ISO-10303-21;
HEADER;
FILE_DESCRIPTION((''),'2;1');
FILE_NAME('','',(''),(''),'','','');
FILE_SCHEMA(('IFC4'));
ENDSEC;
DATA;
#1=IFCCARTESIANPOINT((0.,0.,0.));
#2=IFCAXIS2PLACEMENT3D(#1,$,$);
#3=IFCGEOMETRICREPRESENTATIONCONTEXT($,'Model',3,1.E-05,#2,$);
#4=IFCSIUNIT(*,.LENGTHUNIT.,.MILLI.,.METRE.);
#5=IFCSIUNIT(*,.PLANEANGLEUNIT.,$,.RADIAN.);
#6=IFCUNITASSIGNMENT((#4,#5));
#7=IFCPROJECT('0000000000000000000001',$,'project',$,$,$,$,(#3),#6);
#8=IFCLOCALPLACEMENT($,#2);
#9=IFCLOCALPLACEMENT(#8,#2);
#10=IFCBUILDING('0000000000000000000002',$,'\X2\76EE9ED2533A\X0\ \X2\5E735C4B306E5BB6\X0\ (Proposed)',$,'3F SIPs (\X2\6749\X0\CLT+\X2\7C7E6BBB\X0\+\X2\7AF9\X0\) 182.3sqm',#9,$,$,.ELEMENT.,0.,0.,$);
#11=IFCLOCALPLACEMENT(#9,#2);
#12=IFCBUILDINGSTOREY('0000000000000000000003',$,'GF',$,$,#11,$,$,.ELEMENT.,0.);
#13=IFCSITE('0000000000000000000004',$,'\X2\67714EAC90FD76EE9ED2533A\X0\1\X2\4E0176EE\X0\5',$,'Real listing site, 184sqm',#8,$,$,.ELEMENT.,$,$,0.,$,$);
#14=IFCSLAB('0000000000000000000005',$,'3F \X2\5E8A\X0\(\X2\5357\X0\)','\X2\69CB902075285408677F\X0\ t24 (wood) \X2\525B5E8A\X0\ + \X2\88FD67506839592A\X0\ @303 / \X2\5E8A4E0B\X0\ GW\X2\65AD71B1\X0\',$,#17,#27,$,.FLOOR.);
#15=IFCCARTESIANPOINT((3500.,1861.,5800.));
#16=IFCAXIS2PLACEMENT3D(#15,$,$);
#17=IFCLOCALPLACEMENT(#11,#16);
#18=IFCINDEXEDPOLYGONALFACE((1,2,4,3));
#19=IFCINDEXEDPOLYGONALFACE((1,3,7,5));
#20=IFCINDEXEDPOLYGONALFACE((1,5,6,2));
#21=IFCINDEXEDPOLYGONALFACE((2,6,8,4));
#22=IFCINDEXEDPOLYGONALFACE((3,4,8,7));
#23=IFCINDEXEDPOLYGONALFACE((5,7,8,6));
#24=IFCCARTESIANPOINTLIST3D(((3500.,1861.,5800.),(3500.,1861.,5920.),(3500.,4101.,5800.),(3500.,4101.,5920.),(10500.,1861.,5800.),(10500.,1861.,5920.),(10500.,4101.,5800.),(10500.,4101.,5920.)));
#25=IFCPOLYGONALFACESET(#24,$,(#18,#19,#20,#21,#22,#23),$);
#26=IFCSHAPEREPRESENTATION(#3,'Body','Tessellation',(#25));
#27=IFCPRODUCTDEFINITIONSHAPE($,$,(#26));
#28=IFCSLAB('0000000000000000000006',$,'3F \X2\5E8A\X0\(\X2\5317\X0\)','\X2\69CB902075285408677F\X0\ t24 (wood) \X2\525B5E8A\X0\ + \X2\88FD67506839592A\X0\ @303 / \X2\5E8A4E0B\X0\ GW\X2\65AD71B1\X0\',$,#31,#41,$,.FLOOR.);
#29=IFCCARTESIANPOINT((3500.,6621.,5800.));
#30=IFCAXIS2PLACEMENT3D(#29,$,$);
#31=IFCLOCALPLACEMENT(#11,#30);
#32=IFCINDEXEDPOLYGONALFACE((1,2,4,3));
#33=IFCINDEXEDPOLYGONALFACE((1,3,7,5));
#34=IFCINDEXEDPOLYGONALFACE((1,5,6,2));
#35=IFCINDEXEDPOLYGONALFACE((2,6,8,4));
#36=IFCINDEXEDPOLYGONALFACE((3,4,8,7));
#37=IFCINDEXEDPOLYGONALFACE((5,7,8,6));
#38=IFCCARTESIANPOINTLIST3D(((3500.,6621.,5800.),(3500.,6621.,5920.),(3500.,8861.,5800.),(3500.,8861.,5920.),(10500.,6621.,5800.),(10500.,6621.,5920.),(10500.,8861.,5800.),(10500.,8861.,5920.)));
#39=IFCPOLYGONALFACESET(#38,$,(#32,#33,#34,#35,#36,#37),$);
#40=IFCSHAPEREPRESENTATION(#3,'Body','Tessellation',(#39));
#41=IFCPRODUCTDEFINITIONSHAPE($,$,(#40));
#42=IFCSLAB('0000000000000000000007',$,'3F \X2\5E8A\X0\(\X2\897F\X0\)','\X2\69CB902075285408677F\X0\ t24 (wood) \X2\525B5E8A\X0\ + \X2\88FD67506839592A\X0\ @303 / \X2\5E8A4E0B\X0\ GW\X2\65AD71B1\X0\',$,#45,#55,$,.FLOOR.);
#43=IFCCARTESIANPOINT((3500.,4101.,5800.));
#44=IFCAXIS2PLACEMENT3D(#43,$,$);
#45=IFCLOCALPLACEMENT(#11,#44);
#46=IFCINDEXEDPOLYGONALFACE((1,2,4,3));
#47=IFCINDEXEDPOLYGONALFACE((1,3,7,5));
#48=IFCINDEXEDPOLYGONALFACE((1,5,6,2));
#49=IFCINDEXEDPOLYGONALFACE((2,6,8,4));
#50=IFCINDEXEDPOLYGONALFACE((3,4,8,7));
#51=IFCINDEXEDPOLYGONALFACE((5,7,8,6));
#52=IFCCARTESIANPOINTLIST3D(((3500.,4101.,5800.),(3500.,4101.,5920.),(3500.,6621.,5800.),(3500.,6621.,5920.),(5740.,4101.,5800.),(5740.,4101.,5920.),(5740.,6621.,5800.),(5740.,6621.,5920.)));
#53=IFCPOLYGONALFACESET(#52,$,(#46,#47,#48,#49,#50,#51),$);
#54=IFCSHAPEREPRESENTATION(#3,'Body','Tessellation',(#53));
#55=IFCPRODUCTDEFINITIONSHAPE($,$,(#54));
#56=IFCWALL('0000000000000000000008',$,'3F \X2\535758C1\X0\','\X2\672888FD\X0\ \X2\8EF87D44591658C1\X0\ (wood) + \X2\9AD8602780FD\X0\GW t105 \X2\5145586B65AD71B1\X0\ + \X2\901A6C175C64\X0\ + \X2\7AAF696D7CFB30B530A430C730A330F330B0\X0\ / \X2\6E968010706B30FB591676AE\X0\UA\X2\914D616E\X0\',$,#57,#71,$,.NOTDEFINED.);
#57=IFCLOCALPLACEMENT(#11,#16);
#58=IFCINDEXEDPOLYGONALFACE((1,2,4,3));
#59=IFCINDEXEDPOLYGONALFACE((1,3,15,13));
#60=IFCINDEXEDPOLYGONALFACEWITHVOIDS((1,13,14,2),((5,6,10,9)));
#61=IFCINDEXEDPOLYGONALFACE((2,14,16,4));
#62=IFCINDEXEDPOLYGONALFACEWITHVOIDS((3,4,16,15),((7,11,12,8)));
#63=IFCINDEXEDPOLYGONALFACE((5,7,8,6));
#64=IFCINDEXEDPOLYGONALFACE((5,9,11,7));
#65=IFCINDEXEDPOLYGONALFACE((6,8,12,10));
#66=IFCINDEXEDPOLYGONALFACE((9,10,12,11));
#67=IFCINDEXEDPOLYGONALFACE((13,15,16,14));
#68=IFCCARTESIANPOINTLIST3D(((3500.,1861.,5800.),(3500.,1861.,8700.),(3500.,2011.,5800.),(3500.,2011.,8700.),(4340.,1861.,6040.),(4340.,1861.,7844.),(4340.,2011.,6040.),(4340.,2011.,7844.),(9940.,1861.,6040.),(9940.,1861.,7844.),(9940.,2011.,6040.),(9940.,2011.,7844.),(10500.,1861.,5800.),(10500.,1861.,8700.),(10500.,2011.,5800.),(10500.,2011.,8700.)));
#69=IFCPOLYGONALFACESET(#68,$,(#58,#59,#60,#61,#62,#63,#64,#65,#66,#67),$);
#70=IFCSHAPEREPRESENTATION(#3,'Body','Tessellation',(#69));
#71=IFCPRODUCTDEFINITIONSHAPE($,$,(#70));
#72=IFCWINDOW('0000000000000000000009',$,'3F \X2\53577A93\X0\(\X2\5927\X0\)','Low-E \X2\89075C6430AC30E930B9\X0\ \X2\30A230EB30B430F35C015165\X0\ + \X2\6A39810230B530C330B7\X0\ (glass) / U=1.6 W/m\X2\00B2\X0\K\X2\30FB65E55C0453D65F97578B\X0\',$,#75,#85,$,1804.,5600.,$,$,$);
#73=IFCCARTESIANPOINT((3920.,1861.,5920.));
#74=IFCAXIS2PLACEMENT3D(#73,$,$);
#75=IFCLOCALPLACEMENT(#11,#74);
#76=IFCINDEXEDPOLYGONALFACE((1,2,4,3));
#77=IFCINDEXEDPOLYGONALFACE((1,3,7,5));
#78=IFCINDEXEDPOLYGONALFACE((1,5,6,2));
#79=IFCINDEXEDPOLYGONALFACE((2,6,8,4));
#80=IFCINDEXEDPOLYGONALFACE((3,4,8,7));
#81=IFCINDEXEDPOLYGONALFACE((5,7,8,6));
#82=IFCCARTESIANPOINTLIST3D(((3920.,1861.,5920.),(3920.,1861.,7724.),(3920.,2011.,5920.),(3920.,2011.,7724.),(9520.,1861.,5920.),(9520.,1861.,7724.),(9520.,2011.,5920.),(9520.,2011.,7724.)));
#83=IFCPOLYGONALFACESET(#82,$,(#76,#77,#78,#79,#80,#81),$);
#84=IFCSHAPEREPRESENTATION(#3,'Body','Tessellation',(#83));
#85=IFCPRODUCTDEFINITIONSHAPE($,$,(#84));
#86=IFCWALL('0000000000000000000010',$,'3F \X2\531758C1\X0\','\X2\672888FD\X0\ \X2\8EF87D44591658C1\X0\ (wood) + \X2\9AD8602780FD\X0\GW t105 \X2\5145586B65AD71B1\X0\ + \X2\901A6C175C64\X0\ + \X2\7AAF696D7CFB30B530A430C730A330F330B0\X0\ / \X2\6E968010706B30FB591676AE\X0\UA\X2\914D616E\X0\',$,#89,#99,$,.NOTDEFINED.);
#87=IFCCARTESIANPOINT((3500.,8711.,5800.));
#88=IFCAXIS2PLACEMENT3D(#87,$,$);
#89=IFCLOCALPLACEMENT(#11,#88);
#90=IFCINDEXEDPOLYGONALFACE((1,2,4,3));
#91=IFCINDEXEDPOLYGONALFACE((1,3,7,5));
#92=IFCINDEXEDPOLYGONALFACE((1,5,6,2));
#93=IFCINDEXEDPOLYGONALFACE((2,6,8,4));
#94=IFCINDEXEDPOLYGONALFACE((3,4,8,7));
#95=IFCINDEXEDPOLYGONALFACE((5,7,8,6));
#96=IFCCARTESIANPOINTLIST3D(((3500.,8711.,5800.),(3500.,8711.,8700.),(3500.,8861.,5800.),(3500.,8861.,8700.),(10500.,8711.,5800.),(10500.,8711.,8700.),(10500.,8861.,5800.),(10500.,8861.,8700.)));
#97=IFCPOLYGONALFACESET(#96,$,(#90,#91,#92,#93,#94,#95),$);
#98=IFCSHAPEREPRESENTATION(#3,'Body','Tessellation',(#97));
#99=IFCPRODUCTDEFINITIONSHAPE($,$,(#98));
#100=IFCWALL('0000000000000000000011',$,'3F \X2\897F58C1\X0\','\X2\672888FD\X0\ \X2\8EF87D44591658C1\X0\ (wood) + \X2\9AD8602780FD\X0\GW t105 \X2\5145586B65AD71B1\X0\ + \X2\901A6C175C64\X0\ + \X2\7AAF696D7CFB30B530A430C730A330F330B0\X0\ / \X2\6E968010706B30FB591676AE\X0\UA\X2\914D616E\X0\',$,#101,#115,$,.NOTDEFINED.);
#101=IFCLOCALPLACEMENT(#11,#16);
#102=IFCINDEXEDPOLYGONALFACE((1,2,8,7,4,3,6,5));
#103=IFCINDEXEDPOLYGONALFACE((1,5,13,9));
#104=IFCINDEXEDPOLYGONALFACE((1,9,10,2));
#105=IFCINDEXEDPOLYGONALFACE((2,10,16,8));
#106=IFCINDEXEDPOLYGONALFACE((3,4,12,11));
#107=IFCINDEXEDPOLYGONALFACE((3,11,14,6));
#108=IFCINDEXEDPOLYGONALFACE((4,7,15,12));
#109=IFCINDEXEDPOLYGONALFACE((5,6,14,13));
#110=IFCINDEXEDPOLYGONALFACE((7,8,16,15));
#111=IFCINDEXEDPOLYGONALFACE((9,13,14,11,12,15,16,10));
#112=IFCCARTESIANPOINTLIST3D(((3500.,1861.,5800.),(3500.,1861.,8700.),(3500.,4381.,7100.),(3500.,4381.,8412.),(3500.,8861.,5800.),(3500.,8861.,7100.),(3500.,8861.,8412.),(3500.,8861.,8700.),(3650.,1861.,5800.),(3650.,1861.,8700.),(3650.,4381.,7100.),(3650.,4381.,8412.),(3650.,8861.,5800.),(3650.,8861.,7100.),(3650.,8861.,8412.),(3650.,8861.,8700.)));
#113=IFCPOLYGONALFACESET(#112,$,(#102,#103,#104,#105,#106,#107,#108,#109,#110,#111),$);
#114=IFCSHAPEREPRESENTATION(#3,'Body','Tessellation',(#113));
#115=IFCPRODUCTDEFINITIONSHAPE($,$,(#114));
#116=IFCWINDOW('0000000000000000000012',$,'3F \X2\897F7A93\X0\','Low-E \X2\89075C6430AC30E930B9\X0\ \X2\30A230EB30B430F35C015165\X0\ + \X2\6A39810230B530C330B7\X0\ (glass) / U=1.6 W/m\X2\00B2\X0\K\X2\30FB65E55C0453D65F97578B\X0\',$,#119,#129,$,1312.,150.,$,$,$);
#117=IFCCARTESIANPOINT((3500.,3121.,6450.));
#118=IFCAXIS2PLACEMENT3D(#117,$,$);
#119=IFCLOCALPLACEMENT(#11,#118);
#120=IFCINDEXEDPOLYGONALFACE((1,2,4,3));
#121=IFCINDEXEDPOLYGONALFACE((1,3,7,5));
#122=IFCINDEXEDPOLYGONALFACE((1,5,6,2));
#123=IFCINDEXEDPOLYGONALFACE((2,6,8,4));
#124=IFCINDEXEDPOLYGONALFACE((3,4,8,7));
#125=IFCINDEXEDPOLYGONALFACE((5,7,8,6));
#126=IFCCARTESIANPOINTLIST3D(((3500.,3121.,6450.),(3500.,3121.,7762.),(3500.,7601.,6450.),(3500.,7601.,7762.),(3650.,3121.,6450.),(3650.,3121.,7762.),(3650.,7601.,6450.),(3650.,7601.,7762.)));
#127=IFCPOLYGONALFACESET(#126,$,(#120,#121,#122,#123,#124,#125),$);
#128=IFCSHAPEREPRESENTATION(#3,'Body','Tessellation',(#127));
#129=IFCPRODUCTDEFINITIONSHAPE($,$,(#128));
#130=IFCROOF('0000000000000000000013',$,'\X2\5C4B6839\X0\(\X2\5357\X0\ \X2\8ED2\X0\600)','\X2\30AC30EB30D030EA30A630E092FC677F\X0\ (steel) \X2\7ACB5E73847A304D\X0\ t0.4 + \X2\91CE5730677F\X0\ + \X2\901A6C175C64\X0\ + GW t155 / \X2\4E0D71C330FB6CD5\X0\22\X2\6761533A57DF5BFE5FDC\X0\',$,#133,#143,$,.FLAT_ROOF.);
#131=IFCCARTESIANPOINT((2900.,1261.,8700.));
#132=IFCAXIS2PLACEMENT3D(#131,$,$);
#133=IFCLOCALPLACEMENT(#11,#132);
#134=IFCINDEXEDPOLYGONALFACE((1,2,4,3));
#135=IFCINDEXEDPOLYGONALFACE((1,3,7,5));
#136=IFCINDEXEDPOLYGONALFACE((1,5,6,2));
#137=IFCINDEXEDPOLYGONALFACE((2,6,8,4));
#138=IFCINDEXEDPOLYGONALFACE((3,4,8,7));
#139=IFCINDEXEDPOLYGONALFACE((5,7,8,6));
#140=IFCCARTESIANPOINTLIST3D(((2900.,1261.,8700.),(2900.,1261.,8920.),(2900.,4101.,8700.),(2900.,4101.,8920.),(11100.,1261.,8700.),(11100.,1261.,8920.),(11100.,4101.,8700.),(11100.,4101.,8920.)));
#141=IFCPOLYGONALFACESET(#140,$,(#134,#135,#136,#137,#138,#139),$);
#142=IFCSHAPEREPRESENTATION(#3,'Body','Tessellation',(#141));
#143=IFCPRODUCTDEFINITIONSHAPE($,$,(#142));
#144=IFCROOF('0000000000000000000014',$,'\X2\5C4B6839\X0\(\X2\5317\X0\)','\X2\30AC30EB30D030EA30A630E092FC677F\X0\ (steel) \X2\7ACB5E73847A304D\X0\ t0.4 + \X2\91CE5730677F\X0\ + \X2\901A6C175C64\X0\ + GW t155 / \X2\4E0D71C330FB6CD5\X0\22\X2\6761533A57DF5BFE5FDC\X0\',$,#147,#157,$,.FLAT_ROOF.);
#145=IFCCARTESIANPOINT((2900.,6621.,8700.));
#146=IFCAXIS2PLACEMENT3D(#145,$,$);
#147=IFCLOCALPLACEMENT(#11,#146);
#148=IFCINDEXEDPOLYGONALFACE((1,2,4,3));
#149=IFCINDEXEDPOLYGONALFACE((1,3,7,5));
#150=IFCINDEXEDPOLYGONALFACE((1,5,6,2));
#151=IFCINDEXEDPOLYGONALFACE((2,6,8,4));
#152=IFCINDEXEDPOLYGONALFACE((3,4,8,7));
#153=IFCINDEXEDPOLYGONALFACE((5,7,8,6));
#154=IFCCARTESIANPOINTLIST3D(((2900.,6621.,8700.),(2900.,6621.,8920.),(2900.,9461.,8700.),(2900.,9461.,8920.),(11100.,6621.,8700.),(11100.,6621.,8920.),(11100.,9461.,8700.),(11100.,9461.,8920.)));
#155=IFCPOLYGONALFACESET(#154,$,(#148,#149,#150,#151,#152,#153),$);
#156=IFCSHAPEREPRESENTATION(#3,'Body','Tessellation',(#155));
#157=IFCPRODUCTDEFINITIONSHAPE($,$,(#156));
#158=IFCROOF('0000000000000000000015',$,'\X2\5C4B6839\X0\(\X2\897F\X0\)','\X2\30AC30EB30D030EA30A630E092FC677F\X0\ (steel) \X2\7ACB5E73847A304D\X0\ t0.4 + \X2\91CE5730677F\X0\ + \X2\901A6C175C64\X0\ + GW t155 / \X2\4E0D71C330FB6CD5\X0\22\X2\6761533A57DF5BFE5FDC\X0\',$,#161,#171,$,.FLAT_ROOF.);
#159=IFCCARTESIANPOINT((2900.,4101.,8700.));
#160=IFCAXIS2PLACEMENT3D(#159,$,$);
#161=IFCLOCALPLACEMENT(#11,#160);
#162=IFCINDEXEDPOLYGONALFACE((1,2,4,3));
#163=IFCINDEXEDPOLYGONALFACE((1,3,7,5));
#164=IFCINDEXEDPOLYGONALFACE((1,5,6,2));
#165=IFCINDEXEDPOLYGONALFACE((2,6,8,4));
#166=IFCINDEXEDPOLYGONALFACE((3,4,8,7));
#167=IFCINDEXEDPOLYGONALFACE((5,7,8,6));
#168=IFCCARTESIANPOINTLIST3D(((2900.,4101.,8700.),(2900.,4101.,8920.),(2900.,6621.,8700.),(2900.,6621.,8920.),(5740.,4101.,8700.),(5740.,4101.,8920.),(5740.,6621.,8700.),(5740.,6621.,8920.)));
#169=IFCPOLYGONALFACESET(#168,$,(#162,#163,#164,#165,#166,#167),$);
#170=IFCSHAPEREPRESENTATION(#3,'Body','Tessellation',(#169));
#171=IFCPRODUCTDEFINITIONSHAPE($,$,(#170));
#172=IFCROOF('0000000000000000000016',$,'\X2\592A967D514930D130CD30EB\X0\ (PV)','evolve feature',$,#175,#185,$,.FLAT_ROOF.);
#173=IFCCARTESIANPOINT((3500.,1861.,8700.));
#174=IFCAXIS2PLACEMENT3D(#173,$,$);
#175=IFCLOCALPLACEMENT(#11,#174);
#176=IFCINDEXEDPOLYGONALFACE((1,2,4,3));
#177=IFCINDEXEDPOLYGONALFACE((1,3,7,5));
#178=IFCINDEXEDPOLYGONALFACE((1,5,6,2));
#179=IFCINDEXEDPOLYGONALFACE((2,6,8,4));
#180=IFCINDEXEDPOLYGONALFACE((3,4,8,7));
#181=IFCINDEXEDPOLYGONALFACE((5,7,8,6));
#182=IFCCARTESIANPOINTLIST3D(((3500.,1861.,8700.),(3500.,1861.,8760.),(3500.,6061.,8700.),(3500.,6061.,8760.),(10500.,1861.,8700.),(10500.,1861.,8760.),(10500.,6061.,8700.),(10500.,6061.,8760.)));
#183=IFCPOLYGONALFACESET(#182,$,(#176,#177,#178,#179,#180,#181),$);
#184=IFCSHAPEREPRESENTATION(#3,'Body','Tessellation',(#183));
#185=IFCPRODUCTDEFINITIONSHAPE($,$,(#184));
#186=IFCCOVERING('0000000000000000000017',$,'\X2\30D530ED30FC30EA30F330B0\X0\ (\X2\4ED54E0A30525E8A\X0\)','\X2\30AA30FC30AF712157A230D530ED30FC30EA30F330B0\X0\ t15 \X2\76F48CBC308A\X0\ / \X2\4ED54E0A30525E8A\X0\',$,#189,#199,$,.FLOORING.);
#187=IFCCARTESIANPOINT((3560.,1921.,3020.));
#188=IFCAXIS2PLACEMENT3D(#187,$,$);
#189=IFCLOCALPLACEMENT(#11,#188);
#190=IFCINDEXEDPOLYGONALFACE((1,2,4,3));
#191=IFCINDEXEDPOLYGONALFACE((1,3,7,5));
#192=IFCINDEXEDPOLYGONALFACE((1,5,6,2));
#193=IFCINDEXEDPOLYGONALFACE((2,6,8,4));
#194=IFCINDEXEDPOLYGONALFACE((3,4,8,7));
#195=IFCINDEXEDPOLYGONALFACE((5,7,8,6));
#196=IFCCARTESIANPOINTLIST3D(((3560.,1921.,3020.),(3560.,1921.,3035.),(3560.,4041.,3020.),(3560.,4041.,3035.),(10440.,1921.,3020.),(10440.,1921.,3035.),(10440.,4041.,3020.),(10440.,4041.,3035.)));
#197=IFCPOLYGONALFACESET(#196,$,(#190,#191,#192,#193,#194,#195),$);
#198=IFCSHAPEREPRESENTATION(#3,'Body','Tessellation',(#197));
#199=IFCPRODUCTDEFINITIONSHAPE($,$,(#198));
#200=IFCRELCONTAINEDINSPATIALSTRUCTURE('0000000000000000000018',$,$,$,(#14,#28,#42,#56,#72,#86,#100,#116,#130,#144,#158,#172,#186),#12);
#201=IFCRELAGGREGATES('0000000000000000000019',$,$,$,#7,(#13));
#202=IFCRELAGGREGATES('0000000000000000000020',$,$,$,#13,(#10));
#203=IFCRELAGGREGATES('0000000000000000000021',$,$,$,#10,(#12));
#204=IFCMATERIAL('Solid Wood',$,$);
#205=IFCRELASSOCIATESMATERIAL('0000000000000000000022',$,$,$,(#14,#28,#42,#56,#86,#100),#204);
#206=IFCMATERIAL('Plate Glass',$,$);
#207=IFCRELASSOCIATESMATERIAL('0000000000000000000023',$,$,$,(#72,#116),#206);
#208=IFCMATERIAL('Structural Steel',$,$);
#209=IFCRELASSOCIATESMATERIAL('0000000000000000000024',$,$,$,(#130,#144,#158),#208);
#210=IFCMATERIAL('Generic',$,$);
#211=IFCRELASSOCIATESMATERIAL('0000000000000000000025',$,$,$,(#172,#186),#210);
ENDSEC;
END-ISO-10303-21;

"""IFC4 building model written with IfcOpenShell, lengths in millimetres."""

from ifc_helpers import new_model, si_unit, frame, frame_2d, origin, place, context, project, spatial, rectangle, extrude, material, element, fill, save


model = new_model("IFC4")

# Units and contexts
model_context = context("Model", 3, precision=1e-05, world=origin())
ifc_project = project(units=[si_unit("LENGTHUNIT", "METRE", prefix="MILLI"), si_unit("PLANEANGLEUNIT", "RADIAN")], contexts=[model_context])

# Site, building, storey
site_placement = place(None, origin())
site = spatial("IfcSite", under=ifc_project, at=site_placement, Name="東京都目黒区1丁目5", ObjectType="Real listing site, 184sqm", CompositionType="ELEMENT", RefElevation=0.0)
building_placement = place(site_placement, origin())
building = spatial("IfcBuilding", under=site, at=building_placement, Name="目黒区 平屋の家 (Proposed)", ObjectType="3F SIPs (杉CLT+籾殻+竹) 182.3sqm", CompositionType="ELEMENT", ElevationOfRefHeight=0.0, ElevationOfTerrain=0.0)
storey_placement = place(building_placement, origin())
storey = spatial("IfcBuildingStorey", under=building, at=storey_placement, Name="GF", CompositionType="ELEMENT", Elevation=0.0)

# Slabs
ifc_material_1 = material(Name="Solid Wood")
slab_1_placement = place(storey_placement, frame((3500.0, 1861.0, 5800.0)))
element("IfcSlab", 1, at=slab_1_placement, inside=storey, material=ifc_material_1, Name="3F 床(南)", Description="構造用合板 t24 (wood) 剛床 + 製材根太 @303 / 床下 GW断熱", PredefinedType="FLOOR", context=model_context, shape_type="SweptSolid", body=[
    extrude(rectangle(XDim=7000.0, YDim=2240.0, at=frame_2d((3500.0, 1120.0))), frame((3500.0, 1861.0, 5800.0)), (0.0, 0.0, 1.0), 120.0),
])
slab_2_placement = place(storey_placement, frame((3500.0, 6621.0, 5800.0)))
element("IfcSlab", 2, at=slab_2_placement, inside=storey, material=ifc_material_1, Name="3F 床(北)", Description="構造用合板 t24 (wood) 剛床 + 製材根太 @303 / 床下 GW断熱", PredefinedType="FLOOR", context=model_context, shape_type="SweptSolid", body=[
    extrude(rectangle(XDim=7000.0, YDim=2240.0, at=frame_2d((3500.0, 1120.0))), frame((3500.0, 6621.0, 5800.0)), (0.0, 0.0, 1.0), 120.0),
])
slab_3_placement = place(storey_placement, frame((3500.0, 4101.0, 5800.0)))
element("IfcSlab", 3, at=slab_3_placement, inside=storey, material=ifc_material_1, Name="3F 床(西)", Description="構造用合板 t24 (wood) 剛床 + 製材根太 @303 / 床下 GW断熱", PredefinedType="FLOOR", context=model_context, shape_type="SweptSolid", body=[
    extrude(rectangle(XDim=2240.0, YDim=2520.0, at=frame_2d((1120.0, 1260.0))), frame((3500.0, 4101.0, 5800.0)), (0.0, 0.0, 1.0), 120.0),
])

# Wall, opening, window
wall_1_placement = place(storey_placement, frame((3500.0, 1861.0, 5800.0)))
wall_1 = element("IfcWall", 4, at=wall_1_placement, inside=storey, material=ifc_material_1, Name="3F 南壁", Description="木製 軸組外壁 (wood) + 高性能GW t105 充填断熱 + 通気層 + 窯業系サイディング / 準耐火・外皮UA配慮", PredefinedType="NOTDEFINED", context=model_context, shape_type="SweptSolid", body=[
    extrude(rectangle(XDim=7000.0, YDim=150.0, at=frame_2d((3500.0, 75.0))), frame((3500.0, 1861.0, 5800.0)), (0.0, 0.0, 1.0), 2900.0),
])
opening_1_placement = place(storey_placement, frame((3920.0, 1861.0, 5920.0)))
opening_1 = element("IfcOpeningElement", 5, at=opening_1_placement, cuts=wall_1, PredefinedType="NOTDEFINED", context=model_context, shape_type="SweptSolid", body=[
    extrude(rectangle(XDim=5600.0, YDim=150.0, at=frame_2d((2800.0, 75.0))), frame((3920.0, 1861.0, 5920.0)), (0.0, 0.0, 1.0), 1804.0),
])
ifc_material_2 = material(Name="Plate Glass")
window_1_placement = place(storey_placement, frame((3920.0, 1861.0, 5920.0)))
window_1 = element("IfcWindow", 6, at=window_1_placement, inside=storey, material=ifc_material_2, Name="3F 南窓(大)", Description="Low-E 複層ガラス アルゴン封入 + 樹脂サッシ (glass) / U=1.6 W/m²K・日射取得型", OverallHeight=1804.0, OverallWidth=5600.0, context=model_context, shape_type="SweptSolid", body=[
    extrude(rectangle(XDim=5600.0, YDim=150.0, at=frame_2d((2800.0, 75.0))), frame((3920.0, 1861.0, 5920.0)), (0.0, 0.0, 1.0), 1804.0),
])
fill(opening_1, window_1)

# Wall
wall_2_placement = place(storey_placement, frame((3500.0, 8711.0, 5800.0)))
element("IfcWall", 7, at=wall_2_placement, inside=storey, material=ifc_material_1, Name="3F 北壁", Description="木製 軸組外壁 (wood) + 高性能GW t105 充填断熱 + 通気層 + 窯業系サイディング / 準耐火・外皮UA配慮", PredefinedType="NOTDEFINED", context=model_context, shape_type="SweptSolid", body=[
    extrude(rectangle(XDim=7000.0, YDim=150.0, at=frame_2d((3500.0, 75.0))), frame((3500.0, 8711.0, 5800.0)), (0.0, 0.0, 1.0), 2900.0),
])

# Wall, opening, window
wall_3_placement = place(storey_placement, frame((3500.0, 1861.0, 5800.0)))
wall_3 = element("IfcWall", 8, at=wall_3_placement, inside=storey, material=ifc_material_1, Name="3F 西壁", Description="木製 軸組外壁 (wood) + 高性能GW t105 充填断熱 + 通気層 + 窯業系サイディング / 準耐火・外皮UA配慮", PredefinedType="NOTDEFINED", context=model_context, shape_type="SweptSolid", body=[
    extrude(rectangle(XDim=150.0, YDim=7000.0, at=frame_2d((75.0, 3500.0))), frame((3500.0, 1861.0, 5800.0)), (0.0, 0.0, 1.0), 2900.0),
])
opening_2_placement = place(storey_placement, frame((3500.0, 3121.0, 6450.0)))
opening_2 = element("IfcOpeningElement", 9, at=opening_2_placement, cuts=wall_3, PredefinedType="NOTDEFINED", context=model_context, shape_type="SweptSolid", body=[
    extrude(rectangle(XDim=150.0, YDim=4480.0, at=frame_2d((75.0, 2240.0))), frame((3500.0, 3121.0, 6450.0)), (0.0, 0.0, 1.0), 1312.0),
])
window_2_placement = place(storey_placement, frame((3500.0, 3121.0, 6450.0)))
window_2 = element("IfcWindow", 10, at=window_2_placement, inside=storey, material=ifc_material_2, Name="3F 西窓", Description="Low-E 複層ガラス アルゴン封入 + 樹脂サッシ (glass) / U=1.6 W/m²K・日射取得型", OverallHeight=1312.0, OverallWidth=150.0, context=model_context, shape_type="SweptSolid", body=[
    extrude(rectangle(XDim=150.0, YDim=4480.0, at=frame_2d((75.0, 2240.0))), frame((3500.0, 3121.0, 6450.0)), (0.0, 0.0, 1.0), 1312.0),
])
fill(opening_2, window_2)

# Roofs
ifc_material_3 = material(Name="Structural Steel")
roof_1_placement = place(storey_placement, frame((2900.0, 1261.0, 8700.0)))
element("IfcRoof", 11, at=roof_1_placement, inside=storey, material=ifc_material_3, Name="屋根(南 軒600)", Description="ガルバリウム鋼板 (steel) 立平葺き t0.4 + 野地板 + 通気層 + GW t155 / 不燃・法22条区域対応", PredefinedType="FLAT_ROOF", context=model_context, shape_type="SweptSolid", body=[
    extrude(rectangle(XDim=8200.0, YDim=2840.0, at=frame_2d((4100.0, 1420.0))), frame((2900.0, 1261.0, 8700.0)), (0.0, 0.0, 1.0), 220.0),
])
roof_2_placement = place(storey_placement, frame((2900.0, 6621.0, 8700.0)))
element("IfcRoof", 12, at=roof_2_placement, inside=storey, material=ifc_material_3, Name="屋根(北)", Description="ガルバリウム鋼板 (steel) 立平葺き t0.4 + 野地板 + 通気層 + GW t155 / 不燃・法22条区域対応", PredefinedType="FLAT_ROOF", context=model_context, shape_type="SweptSolid", body=[
    extrude(rectangle(XDim=8200.0, YDim=2840.0, at=frame_2d((4100.0, 1420.0))), frame((2900.0, 6621.0, 8700.0)), (0.0, 0.0, 1.0), 220.0),
])
roof_3_placement = place(storey_placement, frame((2900.0, 4101.0, 8700.0)))
element("IfcRoof", 13, at=roof_3_placement, inside=storey, material=ifc_material_3, Name="屋根(西)", Description="ガルバリウム鋼板 (steel) 立平葺き t0.4 + 野地板 + 通気層 + GW t155 / 不燃・法22条区域対応", PredefinedType="FLAT_ROOF", context=model_context, shape_type="SweptSolid", body=[
    extrude(rectangle(XDim=2840.0, YDim=2520.0, at=frame_2d((1420.0, 1260.0))), frame((2900.0, 4101.0, 8700.0)), (0.0, 0.0, 1.0), 220.0),
])
ifc_material_4 = material(Name="Generic")
roof_4_placement = place(storey_placement, frame((3500.0, 1861.0, 8700.0)))
element("IfcRoof", 14, at=roof_4_placement, inside=storey, material=ifc_material_4, Name="太陽光パネル (PV)", Description="evolve feature", PredefinedType="FLAT_ROOF", context=model_context, shape_type="SweptSolid", body=[
    extrude(rectangle(XDim=7000.0, YDim=4200.0, at=frame_2d((3500.0, 2100.0))), frame((3500.0, 1861.0, 8700.0)), (0.0, 0.0, 1.0), 60.0),
])

# Covering
covering_1_placement = place(storey_placement, frame((3560.0, 1921.0, 3020.0)))
element("IfcCovering", 15, at=covering_1_placement, inside=storey, material=ifc_material_4, Name="フローリング (仕上げ床)", Description="オーク無垢フローリング t15 直貼り / 仕上げ床", PredefinedType="FLOORING", context=model_context, shape_type="SweptSolid", body=[
    extrude(rectangle(XDim=6880.0, YDim=2120.0, at=frame_2d((3440.0, 1060.0))), frame((3560.0, 1921.0, 3020.0)), (0.0, 0.0, 1.0), 15.0),
])

save(model, "model.ifc")
